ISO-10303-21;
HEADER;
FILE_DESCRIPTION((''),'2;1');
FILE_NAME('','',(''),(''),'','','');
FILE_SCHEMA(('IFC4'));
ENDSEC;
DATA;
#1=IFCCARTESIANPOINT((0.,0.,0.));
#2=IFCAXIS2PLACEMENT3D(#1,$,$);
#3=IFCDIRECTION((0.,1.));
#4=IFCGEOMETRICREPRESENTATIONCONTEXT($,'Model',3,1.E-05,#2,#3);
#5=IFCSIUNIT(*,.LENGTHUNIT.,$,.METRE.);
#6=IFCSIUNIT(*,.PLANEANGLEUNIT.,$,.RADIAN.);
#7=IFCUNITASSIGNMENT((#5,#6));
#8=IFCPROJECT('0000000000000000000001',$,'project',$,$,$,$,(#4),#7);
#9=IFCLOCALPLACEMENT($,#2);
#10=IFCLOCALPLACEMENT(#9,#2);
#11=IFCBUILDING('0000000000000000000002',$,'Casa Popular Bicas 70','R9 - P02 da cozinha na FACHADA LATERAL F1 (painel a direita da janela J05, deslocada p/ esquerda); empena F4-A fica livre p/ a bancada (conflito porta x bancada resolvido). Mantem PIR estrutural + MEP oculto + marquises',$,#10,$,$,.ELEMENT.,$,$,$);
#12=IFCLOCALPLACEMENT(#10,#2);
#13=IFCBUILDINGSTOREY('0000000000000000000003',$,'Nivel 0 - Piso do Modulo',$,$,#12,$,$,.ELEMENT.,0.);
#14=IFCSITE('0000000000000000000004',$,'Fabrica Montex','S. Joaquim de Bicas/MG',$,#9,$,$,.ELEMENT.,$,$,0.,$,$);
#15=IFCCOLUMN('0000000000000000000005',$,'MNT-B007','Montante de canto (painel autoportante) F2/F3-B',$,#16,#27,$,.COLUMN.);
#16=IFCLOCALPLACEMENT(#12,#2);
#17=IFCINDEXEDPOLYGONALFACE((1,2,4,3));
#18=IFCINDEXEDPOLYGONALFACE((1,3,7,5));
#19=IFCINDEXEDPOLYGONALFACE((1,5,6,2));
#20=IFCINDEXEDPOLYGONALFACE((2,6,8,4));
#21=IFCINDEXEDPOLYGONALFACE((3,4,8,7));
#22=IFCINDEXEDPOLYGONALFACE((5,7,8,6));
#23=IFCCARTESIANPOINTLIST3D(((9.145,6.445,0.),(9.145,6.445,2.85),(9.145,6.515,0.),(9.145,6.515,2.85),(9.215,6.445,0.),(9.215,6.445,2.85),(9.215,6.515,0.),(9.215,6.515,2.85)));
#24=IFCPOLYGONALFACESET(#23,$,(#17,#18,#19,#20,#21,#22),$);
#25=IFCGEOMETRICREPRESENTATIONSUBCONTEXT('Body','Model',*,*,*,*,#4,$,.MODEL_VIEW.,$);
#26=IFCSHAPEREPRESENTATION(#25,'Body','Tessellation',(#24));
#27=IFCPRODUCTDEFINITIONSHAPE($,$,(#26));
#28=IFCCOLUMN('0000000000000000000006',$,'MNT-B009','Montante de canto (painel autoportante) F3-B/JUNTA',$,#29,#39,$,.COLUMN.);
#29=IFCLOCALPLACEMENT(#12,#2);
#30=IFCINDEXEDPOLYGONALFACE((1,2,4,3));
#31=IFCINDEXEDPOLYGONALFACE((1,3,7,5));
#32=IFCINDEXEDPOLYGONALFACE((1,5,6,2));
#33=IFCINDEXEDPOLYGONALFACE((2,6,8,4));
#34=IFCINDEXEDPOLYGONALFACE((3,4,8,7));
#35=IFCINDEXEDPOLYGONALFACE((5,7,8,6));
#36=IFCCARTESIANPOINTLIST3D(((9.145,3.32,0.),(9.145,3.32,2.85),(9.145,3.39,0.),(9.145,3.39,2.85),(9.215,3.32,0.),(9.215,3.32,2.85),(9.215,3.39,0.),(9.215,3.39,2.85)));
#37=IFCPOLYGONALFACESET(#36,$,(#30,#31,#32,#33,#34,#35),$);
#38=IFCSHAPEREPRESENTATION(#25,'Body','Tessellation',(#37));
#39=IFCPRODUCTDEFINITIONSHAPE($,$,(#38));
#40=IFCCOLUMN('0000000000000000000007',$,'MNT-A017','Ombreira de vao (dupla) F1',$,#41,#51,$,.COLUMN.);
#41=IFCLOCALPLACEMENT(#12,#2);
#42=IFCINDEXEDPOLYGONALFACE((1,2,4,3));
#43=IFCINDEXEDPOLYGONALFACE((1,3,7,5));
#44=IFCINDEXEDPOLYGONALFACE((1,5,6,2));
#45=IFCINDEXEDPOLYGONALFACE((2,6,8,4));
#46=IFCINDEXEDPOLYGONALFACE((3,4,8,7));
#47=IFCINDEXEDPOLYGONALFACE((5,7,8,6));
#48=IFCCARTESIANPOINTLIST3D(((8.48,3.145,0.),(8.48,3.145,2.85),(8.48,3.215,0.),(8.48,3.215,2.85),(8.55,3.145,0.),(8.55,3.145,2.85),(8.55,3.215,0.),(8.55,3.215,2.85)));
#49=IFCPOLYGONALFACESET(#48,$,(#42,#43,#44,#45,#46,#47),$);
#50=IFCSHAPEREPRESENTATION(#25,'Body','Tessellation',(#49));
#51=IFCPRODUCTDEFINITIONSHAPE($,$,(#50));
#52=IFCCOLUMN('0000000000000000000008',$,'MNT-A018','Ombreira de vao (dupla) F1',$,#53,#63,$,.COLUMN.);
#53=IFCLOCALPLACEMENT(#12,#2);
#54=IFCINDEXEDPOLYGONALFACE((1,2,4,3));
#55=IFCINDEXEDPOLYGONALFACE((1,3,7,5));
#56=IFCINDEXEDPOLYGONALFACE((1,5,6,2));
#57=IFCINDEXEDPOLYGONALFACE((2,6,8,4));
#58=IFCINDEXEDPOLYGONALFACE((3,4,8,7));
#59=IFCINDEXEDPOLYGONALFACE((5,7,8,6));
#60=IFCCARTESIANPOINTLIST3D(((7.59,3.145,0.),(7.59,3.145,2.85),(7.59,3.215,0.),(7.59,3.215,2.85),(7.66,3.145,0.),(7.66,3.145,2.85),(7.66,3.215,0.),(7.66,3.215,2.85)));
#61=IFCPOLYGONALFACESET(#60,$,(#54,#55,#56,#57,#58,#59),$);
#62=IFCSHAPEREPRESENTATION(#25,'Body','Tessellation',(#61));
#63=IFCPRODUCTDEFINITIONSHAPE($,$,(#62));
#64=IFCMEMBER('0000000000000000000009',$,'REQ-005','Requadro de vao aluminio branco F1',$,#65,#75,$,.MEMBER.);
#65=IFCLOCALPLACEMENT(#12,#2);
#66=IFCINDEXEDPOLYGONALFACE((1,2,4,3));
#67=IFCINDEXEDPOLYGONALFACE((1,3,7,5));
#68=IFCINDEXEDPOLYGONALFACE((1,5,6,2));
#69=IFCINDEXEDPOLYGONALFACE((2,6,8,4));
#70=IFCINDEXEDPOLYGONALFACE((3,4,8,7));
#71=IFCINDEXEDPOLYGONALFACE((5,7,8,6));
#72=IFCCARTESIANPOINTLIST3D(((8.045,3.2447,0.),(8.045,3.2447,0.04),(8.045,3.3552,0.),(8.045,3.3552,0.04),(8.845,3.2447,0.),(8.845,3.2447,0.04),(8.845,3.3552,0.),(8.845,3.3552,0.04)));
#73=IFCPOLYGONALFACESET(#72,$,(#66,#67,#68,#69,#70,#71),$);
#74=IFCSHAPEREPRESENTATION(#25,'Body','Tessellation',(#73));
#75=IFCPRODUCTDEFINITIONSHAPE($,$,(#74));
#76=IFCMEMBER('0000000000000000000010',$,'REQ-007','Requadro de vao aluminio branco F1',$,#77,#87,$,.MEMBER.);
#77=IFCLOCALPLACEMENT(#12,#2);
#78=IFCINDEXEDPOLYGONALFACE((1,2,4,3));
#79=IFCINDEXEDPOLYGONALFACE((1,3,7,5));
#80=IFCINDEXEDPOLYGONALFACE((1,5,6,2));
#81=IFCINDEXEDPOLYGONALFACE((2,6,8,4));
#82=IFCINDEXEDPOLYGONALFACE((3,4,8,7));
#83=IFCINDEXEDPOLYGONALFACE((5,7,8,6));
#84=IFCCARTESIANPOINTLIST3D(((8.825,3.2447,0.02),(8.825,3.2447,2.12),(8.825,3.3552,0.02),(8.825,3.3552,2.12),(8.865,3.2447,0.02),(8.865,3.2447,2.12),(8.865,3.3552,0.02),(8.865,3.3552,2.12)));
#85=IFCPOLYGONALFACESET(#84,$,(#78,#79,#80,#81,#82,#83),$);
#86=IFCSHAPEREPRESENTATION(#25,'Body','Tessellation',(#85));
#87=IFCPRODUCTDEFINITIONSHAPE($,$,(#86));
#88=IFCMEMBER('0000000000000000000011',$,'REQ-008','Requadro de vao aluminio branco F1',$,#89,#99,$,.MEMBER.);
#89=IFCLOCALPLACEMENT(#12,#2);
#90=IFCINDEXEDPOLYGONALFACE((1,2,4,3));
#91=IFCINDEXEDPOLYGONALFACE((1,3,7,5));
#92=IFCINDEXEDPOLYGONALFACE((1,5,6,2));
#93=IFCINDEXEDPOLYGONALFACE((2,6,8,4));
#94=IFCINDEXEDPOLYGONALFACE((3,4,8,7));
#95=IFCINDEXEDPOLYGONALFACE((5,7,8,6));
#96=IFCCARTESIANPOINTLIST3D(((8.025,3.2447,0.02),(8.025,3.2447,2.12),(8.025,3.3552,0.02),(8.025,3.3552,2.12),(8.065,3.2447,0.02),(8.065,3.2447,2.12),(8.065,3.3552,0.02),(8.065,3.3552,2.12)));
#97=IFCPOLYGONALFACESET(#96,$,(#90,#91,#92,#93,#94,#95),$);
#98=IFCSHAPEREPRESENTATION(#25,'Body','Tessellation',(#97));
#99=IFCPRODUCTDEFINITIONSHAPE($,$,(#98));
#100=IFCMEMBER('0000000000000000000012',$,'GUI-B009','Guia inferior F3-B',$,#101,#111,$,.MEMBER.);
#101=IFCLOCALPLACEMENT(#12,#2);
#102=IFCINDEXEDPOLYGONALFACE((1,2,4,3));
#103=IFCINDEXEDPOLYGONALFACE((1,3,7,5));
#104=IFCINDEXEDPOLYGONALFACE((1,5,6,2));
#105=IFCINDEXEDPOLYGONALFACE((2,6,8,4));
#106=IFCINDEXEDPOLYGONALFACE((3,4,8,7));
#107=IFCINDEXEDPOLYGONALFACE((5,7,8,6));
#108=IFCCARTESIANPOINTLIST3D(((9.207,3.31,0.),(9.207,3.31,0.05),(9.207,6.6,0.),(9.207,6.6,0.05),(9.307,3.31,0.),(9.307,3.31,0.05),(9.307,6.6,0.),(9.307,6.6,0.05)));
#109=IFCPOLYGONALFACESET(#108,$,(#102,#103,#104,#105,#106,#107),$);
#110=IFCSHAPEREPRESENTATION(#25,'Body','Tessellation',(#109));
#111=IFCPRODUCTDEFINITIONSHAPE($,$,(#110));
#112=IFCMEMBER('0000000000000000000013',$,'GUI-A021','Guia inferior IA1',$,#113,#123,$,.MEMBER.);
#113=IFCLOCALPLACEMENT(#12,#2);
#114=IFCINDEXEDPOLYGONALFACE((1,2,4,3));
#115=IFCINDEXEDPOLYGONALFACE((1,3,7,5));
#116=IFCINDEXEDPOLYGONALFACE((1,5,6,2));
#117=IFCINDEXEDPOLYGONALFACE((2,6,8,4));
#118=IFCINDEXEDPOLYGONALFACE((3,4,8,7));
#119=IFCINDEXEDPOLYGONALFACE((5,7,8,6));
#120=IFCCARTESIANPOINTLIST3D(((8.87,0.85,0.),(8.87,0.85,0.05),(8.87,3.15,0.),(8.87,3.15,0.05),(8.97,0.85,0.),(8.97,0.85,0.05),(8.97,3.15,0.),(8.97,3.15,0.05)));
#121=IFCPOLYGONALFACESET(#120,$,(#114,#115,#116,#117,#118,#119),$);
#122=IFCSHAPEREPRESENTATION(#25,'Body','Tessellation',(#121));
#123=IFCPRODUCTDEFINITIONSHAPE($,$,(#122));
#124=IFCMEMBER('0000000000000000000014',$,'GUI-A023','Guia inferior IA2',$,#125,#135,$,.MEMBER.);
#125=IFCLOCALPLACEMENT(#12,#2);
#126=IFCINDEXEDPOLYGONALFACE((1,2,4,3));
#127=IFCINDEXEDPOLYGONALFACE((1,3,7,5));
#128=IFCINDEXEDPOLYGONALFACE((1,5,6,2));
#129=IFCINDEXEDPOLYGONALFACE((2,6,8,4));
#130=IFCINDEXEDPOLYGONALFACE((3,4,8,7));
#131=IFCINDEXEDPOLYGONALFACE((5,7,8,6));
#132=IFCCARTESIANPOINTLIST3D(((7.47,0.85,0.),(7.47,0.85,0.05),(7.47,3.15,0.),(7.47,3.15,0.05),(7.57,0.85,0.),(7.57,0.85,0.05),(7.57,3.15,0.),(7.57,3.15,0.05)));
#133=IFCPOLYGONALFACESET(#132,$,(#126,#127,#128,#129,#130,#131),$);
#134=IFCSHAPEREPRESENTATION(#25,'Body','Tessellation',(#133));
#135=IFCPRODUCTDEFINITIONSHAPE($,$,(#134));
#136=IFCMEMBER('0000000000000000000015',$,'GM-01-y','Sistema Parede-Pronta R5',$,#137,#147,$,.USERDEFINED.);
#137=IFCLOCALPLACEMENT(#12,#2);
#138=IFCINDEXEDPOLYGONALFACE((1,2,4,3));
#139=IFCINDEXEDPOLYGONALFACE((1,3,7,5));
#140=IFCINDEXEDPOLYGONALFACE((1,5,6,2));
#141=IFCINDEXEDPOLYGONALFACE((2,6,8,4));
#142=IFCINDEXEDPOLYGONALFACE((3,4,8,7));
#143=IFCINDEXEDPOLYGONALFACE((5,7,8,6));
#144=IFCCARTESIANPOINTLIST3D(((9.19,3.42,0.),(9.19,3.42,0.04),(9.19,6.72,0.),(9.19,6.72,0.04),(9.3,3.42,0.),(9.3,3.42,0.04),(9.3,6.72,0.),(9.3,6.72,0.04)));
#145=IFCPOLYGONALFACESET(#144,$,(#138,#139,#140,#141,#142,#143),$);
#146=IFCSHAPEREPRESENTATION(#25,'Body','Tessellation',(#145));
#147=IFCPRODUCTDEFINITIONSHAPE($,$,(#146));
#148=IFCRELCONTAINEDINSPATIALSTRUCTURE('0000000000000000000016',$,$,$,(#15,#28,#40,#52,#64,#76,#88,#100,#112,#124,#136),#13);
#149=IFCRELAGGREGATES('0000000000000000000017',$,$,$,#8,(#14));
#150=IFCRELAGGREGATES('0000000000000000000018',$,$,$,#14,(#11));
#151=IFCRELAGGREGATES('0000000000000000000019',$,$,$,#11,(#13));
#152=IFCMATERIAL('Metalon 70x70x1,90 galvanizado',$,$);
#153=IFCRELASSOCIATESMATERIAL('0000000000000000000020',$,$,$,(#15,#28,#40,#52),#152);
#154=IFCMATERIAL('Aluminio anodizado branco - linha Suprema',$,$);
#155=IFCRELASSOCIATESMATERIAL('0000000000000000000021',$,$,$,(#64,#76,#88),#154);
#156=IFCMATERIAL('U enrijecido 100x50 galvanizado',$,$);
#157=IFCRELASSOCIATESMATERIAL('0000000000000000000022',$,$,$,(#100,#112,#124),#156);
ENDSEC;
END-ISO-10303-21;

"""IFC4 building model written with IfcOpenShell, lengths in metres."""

from ifc_helpers import new_model, si_unit, direction, frame, origin, origin_2d, place, context, subcontext, project, spatial, rectangle, extrude, material, element, save


model = new_model("IFC4")

# Units and contexts
model_context = context("Model", 3, precision=1e-05, world=origin(), true_north=direction((0.0, 1.0)))
body_context = subcontext(model_context, "Body", "Model", "MODEL_VIEW")
ifc_project = project(units=[si_unit("LENGTHUNIT", "METRE"), si_unit("PLANEANGLEUNIT", "RADIAN")], contexts=[model_context])

# Site, building, storey
site_placement = place(None, origin())
site = spatial("IfcSite", under=ifc_project, at=site_placement, Name="Fabrica Montex", Description="S. Joaquim de Bicas/MG", CompositionType="ELEMENT", RefElevation=0.0)
building_placement = place(site_placement, origin())
building = spatial("IfcBuilding", under=site, at=building_placement, Name="Casa Popular Bicas 70", Description="R9 - P02 da cozinha na FACHADA LATERAL F1 (painel a direita da janela J05, deslocada p/ esquerda); empena F4-A fica livre p/ a bancada (conflito porta x bancada resolvido). Mantem PIR estrutural + MEP oculto + marquises", CompositionType="ELEMENT")
storey_placement = place(building_placement, origin())
storey = spatial("IfcBuildingStorey", under=building, at=storey_placement, Name="Nivel 0 - Piso do Modulo", CompositionType="ELEMENT", Elevation=0.0)

# Columns
ifc_material_1 = material(Name="Metalon 70x70x1,90 galvanizado")
for number, where, name, description in (
    (1, (9.18, 6.48, 0.0), "MNT-B007", "Montante de canto (painel autoportante) F2/F3-B"),
    (2, (9.18, 3.355, 0.0), "MNT-B009", "Montante de canto (painel autoportante) F3-B/JUNTA"),
):
    element("IfcColumn", number, at=place(storey_placement, frame(where)), inside=storey, material=ifc_material_1, Name=name, Description=description, PredefinedType="COLUMN", context=body_context, shape_type="SweptSolid", body=[
        extrude(rectangle(XDim=0.07, YDim=0.07, at=origin_2d()), origin(), (0.0, 0.0, 1.0), 2.85),
    ])
for number, where, z_axis, x_axis, name in (
    (3, (8.515, 3.18, 0.0), (0.0, 0.0, 1.0), (-1.0, 0.0, 0.0), "MNT-A017"),
    (4, (7.625, 3.18, 0.0), (0.0, 0.0, 1.0), (-1.0, 0.0, 0.0), "MNT-A018"),
):
    element("IfcColumn", number, at=place(None, frame(where, z_axis=z_axis, x_axis=x_axis)), inside=storey, material=ifc_material_1, Name=name, Description="Ombreira de vao (dupla) F1", PredefinedType="COLUMN", context=body_context, shape_type="SweptSolid", body=[
        extrude(rectangle(XDim=0.07, YDim=0.07, at=origin_2d()), origin(), (0.0, 0.0, 1.0), 2.85),
    ])

# Members
ifc_material_2 = material(Name="Aluminio anodizado branco - linha Suprema")
member_1_placement = place(None, frame((8.845, 3.3, 0.02), z_axis=(-1.0, 0.0, 0.0), x_axis=(0.0, 0.0, 1.0)))
element("IfcMember", 5, at=member_1_placement, inside=storey, material=ifc_material_2, Name="REQ-005", Description="Requadro de vao aluminio branco F1", PredefinedType="MEMBER", context=body_context, shape_type="SweptSolid", body=[
    extrude(rectangle(XDim=0.04, YDim=0.1105, at=origin_2d()), origin(), (0.0, 0.0, 1.0), 0.8),
])
for number, where, z_axis, x_axis, name in (
    (6, (8.845, 3.3, 0.02), (0.0, 0.0, 1.0), (-1.0, 0.0, 0.0), "REQ-007"),
    (7, (8.045, 3.3, 0.02), (0.0, 0.0, 1.0), (-1.0, 0.0, 0.0), "REQ-008"),
):
    element("IfcMember", number, at=place(None, frame(where, z_axis=z_axis, x_axis=x_axis)), inside=storey, material=ifc_material_2, Name=name, Description="Requadro de vao aluminio branco F1", PredefinedType="MEMBER", context=body_context, shape_type="SweptSolid", body=[
        extrude(rectangle(XDim=0.04, YDim=0.1105, at=origin_2d()), origin(), (0.0, 0.0, 1.0), 2.1),
    ])
ifc_material_3 = material(Name="U enrijecido 100x50 galvanizado")
member_2_placement = place(storey_placement, frame((9.257, 3.31, 0.025), z_axis=(0.0, 1.0, 0.0), x_axis=(0.0, 0.0, 1.0)))
element("IfcMember", 8, at=member_2_placement, inside=storey, material=ifc_material_3, Name="GUI-B009", Description="Guia inferior F3-B", PredefinedType="MEMBER", context=body_context, shape_type="SweptSolid", body=[
    extrude(rectangle(XDim=0.05, YDim=0.1, at=origin_2d()), origin(), (0.0, 0.0, 1.0), 3.29),
])
for number, where, z_axis, x_axis, name, description in (
    (9, (8.92, 3.15, 0.025), (0.0, -1.0, 0.0), (0.0, 0.0, 1.0), "GUI-A021", "Guia inferior IA1"),
    (10, (7.52, 3.15, 0.025), (0.0, -1.0, 0.0), (0.0, 0.0, 1.0), "GUI-A023", "Guia inferior IA2"),
):
    element("IfcMember", number, at=place(None, frame(where, z_axis=z_axis, x_axis=x_axis)), inside=storey, material=ifc_material_3, Name=name, Description=description, PredefinedType="MEMBER", context=body_context, shape_type="SweptSolid", body=[
        extrude(rectangle(XDim=0.05, YDim=0.1, at=origin_2d()), origin(), (0.0, 0.0, 1.0), 2.3),
    ])
member_3_placement = place(storey_placement, frame((9.245, 5.07, 0.0)))
element("IfcMember", 11, at=member_3_placement, inside=storey, Name="GM-01-y", Description="Sistema Parede-Pronta R5", PredefinedType="USERDEFINED", context=body_context, shape_type="SweptSolid", body=[
    extrude(rectangle(XDim=0.11, YDim=3.3, at=origin_2d()), origin(), (0.0, 0.0, 1.0), 0.04),
])

save(model, "model.ifc")
